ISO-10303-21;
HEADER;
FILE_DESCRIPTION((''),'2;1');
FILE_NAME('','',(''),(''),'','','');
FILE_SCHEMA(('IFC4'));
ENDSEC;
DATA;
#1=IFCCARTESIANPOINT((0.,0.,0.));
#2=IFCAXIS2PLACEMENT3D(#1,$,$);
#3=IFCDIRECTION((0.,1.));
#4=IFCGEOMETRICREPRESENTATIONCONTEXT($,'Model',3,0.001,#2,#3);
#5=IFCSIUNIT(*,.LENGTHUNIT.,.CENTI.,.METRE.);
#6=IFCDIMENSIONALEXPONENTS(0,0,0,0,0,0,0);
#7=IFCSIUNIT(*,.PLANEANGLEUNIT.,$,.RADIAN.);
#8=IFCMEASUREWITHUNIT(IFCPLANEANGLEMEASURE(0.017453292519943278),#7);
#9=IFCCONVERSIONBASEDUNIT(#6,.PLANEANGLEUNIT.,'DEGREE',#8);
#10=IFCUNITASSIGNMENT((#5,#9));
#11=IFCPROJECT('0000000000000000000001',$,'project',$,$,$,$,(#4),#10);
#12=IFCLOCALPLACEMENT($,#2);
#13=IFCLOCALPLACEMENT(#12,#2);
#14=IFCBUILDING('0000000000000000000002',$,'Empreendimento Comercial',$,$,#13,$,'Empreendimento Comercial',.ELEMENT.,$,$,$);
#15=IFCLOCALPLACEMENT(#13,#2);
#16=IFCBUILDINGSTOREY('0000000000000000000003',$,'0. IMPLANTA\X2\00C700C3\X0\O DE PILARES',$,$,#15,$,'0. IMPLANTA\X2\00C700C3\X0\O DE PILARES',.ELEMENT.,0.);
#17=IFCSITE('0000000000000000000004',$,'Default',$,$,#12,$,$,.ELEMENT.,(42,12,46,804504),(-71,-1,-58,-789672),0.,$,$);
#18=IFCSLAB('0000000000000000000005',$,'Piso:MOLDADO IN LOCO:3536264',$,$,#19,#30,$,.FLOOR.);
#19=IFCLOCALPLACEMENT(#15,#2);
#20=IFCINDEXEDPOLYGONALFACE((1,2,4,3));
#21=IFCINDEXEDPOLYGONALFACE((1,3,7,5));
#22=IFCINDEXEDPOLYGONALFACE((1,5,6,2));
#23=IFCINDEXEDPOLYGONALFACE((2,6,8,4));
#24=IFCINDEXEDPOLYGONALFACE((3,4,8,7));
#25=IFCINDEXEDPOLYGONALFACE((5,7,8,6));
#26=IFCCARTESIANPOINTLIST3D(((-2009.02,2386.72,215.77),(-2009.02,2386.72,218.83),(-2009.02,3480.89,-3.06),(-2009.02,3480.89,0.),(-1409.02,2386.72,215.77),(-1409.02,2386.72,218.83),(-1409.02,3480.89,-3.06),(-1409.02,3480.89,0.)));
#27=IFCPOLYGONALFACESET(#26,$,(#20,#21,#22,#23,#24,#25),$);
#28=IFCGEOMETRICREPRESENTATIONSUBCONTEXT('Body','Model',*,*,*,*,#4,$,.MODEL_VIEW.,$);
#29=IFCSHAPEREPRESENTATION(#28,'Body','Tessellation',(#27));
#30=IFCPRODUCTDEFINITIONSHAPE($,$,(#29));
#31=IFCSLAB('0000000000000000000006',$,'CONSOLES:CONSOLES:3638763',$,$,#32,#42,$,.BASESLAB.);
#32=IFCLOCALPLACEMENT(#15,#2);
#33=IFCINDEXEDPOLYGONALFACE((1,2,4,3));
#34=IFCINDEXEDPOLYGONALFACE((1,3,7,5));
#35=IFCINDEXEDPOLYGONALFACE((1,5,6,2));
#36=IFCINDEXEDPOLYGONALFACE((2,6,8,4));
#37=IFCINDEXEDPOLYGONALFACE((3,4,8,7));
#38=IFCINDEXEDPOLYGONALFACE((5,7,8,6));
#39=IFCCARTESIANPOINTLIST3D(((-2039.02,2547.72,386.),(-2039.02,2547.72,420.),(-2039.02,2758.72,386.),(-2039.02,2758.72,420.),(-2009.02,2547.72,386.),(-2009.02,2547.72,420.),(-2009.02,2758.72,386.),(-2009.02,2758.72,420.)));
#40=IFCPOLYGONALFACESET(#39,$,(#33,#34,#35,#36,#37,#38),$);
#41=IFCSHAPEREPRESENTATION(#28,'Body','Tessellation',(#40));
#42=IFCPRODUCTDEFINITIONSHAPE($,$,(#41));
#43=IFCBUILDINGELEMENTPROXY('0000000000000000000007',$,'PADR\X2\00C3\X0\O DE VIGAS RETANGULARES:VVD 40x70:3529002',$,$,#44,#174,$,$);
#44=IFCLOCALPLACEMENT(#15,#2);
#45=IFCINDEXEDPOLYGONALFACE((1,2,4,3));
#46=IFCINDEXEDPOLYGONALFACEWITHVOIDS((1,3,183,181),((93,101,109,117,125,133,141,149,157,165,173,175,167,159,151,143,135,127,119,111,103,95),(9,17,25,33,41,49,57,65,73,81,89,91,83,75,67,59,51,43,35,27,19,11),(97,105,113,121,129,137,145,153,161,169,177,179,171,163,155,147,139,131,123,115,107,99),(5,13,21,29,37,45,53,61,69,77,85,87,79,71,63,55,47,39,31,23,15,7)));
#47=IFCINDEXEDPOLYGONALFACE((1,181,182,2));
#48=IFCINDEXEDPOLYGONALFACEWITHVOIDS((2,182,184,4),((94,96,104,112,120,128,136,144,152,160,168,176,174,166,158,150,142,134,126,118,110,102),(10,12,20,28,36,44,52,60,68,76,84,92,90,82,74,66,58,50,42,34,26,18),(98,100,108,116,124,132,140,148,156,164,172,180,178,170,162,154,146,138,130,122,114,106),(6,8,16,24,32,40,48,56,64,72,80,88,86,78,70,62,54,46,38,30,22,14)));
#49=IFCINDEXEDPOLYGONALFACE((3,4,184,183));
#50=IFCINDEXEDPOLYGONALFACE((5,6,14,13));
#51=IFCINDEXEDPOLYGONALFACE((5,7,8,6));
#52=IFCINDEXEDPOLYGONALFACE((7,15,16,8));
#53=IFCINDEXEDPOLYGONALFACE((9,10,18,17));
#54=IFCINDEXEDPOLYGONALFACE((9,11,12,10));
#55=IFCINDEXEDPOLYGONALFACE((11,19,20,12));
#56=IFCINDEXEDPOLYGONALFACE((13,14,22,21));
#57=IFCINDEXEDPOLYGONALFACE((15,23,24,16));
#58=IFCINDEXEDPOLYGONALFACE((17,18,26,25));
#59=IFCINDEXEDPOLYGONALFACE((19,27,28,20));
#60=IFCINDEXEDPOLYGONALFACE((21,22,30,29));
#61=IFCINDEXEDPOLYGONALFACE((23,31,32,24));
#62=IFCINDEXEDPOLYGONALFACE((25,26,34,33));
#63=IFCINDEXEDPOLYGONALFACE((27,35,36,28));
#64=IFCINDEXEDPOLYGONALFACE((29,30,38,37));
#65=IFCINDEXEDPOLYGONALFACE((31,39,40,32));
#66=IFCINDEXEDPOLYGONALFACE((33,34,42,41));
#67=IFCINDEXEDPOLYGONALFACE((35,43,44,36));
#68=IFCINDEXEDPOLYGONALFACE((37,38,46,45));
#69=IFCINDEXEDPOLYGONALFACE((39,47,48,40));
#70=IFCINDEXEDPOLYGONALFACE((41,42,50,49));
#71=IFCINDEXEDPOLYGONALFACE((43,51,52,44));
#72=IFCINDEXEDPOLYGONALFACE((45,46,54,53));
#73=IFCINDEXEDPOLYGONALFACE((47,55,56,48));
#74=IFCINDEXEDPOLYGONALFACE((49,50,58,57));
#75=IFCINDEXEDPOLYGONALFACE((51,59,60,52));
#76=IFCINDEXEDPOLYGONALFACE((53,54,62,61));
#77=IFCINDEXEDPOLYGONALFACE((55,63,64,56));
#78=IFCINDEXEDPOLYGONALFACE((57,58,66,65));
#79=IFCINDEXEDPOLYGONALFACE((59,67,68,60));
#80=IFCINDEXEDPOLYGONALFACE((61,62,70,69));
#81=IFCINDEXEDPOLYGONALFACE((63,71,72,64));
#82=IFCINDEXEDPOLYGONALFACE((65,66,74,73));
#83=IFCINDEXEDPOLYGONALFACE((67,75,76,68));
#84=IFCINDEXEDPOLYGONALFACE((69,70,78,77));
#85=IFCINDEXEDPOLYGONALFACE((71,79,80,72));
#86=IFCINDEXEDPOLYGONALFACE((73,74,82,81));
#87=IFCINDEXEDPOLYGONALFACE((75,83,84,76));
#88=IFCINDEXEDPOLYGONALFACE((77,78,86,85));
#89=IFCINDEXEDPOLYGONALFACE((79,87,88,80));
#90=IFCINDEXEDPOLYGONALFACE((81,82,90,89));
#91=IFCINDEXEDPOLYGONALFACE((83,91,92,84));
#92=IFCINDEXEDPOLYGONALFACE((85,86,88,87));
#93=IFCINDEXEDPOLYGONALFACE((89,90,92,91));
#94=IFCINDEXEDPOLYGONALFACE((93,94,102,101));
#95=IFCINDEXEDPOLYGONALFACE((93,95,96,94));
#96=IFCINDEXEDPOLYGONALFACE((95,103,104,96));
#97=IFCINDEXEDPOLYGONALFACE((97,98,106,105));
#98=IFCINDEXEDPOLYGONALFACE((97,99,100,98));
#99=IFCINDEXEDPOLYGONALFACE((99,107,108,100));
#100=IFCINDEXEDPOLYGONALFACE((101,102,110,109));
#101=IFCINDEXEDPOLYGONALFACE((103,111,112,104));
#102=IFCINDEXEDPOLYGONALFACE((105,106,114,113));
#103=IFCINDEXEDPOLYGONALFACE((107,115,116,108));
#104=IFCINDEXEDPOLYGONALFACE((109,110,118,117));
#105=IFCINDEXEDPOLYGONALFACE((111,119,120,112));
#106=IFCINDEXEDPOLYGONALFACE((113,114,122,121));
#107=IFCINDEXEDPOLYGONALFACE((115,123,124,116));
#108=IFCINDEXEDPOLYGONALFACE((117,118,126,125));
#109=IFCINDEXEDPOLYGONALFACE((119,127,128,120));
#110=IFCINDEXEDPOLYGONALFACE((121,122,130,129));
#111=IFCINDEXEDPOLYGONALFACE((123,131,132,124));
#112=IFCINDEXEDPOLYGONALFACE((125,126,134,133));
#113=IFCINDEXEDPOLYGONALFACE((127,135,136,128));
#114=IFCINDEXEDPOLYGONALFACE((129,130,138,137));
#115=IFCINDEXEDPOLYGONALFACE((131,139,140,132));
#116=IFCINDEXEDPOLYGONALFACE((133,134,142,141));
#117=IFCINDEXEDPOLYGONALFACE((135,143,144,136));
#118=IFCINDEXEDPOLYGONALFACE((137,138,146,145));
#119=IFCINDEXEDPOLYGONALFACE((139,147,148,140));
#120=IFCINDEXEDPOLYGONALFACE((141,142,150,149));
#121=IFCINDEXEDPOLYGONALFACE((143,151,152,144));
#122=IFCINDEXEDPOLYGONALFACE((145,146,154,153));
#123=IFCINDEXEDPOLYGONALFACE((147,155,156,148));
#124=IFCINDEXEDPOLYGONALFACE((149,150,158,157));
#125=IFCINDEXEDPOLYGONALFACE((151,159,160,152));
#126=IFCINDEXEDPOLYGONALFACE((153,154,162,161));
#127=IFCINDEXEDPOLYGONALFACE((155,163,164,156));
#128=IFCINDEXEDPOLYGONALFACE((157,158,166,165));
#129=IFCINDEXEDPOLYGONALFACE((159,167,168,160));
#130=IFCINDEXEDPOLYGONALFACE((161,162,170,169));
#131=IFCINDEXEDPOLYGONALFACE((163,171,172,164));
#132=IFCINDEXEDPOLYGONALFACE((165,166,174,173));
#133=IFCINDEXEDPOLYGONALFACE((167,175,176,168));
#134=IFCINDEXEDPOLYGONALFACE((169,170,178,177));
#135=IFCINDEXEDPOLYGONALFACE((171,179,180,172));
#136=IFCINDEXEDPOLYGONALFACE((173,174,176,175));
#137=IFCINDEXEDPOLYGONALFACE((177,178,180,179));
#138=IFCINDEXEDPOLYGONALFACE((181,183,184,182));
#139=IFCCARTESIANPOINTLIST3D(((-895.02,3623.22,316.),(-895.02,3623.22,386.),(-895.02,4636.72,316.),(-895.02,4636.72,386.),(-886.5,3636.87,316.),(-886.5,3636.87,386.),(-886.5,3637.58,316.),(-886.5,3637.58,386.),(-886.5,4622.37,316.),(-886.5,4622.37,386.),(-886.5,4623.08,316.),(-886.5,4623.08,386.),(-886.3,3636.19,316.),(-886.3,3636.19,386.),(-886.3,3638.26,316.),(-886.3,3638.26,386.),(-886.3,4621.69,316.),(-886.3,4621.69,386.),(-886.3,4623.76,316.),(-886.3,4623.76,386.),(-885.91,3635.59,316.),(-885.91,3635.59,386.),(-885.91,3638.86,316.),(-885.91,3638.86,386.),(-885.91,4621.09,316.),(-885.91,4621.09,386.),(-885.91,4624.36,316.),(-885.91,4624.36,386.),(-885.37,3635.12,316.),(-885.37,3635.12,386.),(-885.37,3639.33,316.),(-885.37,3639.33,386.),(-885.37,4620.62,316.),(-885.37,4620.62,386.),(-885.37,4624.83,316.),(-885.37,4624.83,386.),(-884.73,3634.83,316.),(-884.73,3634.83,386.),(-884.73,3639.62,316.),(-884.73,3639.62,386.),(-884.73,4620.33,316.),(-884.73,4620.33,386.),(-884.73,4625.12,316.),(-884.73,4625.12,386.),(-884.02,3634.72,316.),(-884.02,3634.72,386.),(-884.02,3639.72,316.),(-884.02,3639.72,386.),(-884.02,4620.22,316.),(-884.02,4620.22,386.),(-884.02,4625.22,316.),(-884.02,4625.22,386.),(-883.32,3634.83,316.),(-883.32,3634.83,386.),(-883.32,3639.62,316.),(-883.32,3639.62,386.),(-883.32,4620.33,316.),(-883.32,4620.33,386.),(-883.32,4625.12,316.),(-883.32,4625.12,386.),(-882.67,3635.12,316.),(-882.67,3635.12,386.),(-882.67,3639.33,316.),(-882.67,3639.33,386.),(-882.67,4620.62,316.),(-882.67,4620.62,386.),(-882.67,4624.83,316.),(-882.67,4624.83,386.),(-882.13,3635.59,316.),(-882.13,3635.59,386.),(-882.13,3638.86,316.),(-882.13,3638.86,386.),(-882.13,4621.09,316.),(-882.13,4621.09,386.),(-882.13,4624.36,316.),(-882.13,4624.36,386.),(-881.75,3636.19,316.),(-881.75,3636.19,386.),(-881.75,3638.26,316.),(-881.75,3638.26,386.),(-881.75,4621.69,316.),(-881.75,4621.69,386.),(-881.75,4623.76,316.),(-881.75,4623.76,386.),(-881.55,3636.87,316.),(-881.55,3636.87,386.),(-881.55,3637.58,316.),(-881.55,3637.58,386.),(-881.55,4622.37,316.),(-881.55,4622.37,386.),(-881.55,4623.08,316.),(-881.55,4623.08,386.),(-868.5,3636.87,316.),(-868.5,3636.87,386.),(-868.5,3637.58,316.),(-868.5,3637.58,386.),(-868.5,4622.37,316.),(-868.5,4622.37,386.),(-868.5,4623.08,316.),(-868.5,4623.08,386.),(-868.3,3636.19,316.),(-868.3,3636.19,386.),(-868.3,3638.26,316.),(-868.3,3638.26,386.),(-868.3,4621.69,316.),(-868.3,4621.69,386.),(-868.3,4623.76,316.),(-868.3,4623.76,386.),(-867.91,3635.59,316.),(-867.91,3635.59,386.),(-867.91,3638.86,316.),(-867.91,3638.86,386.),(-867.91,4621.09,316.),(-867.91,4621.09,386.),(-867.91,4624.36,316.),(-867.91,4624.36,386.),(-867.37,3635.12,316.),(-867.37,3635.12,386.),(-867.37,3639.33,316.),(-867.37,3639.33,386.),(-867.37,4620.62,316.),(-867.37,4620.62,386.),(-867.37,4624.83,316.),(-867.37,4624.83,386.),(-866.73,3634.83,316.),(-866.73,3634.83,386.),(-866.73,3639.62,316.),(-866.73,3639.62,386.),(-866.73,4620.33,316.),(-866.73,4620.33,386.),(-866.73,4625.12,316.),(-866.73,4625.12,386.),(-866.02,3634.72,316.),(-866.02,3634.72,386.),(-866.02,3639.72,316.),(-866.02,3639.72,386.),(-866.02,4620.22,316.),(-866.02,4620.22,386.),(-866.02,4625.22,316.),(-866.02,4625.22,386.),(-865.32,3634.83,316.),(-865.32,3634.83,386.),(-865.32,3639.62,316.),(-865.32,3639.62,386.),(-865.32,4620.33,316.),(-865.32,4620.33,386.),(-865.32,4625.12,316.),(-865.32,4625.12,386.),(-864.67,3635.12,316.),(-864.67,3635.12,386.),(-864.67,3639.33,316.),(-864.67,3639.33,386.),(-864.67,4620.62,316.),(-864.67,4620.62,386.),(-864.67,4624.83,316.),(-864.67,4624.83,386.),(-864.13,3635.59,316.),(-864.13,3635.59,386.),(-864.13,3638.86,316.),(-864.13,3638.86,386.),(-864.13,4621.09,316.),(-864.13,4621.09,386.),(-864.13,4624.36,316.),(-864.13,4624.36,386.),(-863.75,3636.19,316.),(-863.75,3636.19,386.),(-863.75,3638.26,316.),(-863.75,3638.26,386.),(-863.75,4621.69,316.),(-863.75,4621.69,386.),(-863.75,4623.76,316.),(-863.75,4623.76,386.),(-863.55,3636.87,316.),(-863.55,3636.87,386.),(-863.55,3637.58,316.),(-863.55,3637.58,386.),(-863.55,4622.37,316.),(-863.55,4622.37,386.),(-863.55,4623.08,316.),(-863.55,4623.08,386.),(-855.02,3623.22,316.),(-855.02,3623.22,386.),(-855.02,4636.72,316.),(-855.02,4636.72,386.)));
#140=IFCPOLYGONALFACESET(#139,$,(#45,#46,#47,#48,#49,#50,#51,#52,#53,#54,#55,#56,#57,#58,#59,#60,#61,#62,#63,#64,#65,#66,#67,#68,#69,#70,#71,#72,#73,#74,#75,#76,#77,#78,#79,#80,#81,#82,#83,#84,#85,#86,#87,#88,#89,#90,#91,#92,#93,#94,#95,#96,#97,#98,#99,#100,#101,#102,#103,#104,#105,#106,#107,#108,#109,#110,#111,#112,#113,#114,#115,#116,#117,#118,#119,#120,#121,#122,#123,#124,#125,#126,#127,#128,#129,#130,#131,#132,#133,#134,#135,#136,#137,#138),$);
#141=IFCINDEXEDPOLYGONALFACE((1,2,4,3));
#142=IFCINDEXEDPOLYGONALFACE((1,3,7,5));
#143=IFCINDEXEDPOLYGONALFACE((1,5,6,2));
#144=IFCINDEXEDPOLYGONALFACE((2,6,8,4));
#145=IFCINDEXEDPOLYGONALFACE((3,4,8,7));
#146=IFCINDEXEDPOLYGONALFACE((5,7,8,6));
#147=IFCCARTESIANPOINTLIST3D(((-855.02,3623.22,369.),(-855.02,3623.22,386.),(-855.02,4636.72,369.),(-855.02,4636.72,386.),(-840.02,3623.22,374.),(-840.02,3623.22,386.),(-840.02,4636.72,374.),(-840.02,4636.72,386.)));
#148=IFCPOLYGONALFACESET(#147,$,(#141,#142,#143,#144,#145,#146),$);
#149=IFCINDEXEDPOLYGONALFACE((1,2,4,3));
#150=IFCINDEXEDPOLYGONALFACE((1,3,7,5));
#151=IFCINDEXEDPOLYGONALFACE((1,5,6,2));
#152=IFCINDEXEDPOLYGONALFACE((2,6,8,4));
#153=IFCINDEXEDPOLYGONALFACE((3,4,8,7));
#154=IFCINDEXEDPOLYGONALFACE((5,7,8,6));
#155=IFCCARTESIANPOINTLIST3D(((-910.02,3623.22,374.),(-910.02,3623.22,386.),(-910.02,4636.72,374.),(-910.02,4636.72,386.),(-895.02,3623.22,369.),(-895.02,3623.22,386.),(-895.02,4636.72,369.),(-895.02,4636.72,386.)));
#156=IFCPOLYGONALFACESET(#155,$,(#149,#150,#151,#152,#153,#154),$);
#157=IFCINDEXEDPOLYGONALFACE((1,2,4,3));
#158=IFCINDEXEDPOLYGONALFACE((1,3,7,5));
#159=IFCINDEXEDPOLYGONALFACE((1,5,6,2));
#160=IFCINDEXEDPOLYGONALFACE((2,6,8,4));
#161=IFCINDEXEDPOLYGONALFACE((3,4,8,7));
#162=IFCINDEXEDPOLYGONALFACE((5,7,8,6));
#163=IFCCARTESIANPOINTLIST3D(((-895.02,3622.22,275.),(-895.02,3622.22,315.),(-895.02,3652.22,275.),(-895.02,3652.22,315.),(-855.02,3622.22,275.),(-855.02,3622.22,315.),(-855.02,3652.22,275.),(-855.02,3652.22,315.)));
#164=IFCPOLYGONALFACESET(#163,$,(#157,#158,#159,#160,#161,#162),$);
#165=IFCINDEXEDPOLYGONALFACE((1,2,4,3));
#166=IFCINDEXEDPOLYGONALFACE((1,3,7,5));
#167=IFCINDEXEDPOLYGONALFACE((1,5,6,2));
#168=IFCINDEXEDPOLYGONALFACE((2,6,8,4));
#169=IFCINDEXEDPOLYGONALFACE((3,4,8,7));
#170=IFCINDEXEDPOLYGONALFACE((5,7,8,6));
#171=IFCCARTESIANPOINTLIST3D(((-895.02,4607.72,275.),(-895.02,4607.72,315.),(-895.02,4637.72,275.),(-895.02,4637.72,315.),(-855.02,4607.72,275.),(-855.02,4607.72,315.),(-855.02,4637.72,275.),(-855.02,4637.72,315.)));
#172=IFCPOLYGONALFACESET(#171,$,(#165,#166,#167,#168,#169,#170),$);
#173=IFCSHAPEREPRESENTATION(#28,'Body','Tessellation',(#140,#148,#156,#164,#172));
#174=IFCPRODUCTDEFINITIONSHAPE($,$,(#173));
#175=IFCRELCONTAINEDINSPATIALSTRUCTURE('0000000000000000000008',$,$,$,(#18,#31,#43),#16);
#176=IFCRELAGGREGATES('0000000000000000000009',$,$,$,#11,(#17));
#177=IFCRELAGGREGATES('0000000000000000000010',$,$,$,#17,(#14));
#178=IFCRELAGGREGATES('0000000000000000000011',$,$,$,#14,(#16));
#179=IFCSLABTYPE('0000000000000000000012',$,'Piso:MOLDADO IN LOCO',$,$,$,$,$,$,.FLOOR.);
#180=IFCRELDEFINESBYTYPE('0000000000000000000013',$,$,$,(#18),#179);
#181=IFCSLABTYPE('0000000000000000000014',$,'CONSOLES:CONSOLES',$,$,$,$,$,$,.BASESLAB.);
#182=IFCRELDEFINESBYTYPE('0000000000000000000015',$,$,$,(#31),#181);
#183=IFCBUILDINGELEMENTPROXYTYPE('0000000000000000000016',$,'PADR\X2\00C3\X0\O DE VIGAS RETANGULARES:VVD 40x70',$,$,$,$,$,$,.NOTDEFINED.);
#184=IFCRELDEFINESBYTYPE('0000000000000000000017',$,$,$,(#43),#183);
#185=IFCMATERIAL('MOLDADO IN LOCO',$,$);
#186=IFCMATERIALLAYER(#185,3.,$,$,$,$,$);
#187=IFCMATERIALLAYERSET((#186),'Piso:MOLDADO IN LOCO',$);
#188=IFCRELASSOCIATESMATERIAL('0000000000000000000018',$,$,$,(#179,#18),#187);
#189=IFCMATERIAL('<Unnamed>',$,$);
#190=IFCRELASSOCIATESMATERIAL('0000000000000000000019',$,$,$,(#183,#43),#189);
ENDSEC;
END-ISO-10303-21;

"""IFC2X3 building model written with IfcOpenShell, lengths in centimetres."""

from ifc_helpers import new_model, entity, si_unit, converted_unit, direction, frame, frame_2d, origin, place, context, subcontext, project, spatial, polyline, circle_curve, parameter, trimmed, segment, composite_curve, rectangle, outline, extrude, clip, halfspace, source, transform, mapped, material, layer, layer_set, layer_usage, type_object, type_shapes, element, save


model = new_model("IFC2X3")

# Units and contexts
model_context = context("Model", 3, precision=0.001, world=origin(), true_north=direction((0.0, 1.0)))
body_context = subcontext(model_context, "Body", "Model", "MODEL_VIEW")
ifc_project = project(units=[si_unit("LENGTHUNIT", "METRE", prefix="CENTI"), converted_unit("PLANEANGLEUNIT", "DEGREE", entity("IfcPlaneAngleMeasure", 0.017453292519943278), si_unit("PLANEANGLEUNIT", "RADIAN"), dimensions=[0, 0, 0, 0, 0, 0, 0])], contexts=[model_context])

# Site, building, storey
site_placement = place(None, origin())
site = spatial("IfcSite", under=ifc_project, at=site_placement, Name="Default", CompositionType="ELEMENT", RefLatitude=(42, 12, 46, 804504), RefLongitude=(-71, -1, -58, -789672), RefElevation=0.0)
building_placement = place(site_placement, origin())
building = spatial("IfcBuilding", under=site, at=building_placement, Name="Empreendimento Comercial", LongName="Empreendimento Comercial", CompositionType="ELEMENT")
storey_placement = place(building_placement, origin())
storey = spatial("IfcBuildingStorey", under=building, at=storey_placement, Name="0. IMPLANTAÇÃO DE PILARES", LongName="0. IMPLANTAÇÃO DE PILARES", CompositionType="ELEMENT", Elevation=0.0)

# Slabs
ifc_material_1 = material(Name="MOLDADO IN LOCO")
ifc_layer_1 = layer(ifc_material_1, 3.0)
ifc_layer_set_1 = layer_set([ifc_layer_1], Name="Piso:MOLDADO IN LOCO")
ifc_layer_usage_1 = layer_usage(ifc_layer_set_1, "AXIS3", "POSITIVE", 0.0)
slab_type_1 = type_object("IfcSlabType", Name="Piso:MOLDADO IN LOCO", PredefinedType="FLOOR", material=ifc_layer_set_1)
slab_1_placement = place(storey_placement, origin())
element("IfcSlab", 1, at=slab_1_placement, inside=storey, type_object=slab_type_1, material=ifc_layer_usage_1, Name="Piso:MOLDADO IN LOCO:3536264", PredefinedType="FLOOR", context=body_context, shape_type="Clipping", body=[
    clip(clip(extrude(rectangle(XDim=1115.83, YDim=600.0, at=frame_2d((0.0, 0.0), x_axis=(1.0, 0.0))), frame((-1709.02, 2933.81, 109.42), z_axis=(0.0, -0.196116, -0.980581), x_axis=(0.0, 0.980581, -0.196116)), (0.196116, 0.0, 0.980581), 3.12), halfspace(frame((-1679.02, 3480.89, -3.06), z_axis=(0.0, -0.196116, -0.980581), x_axis=(0.0, -0.980581, 0.196116)), False)), halfspace(frame((-1679.02, 3480.89, 0.0), z_axis=(0.0, 0.196116, 0.980581), x_axis=(0.0, 0.980581, -0.196116)), False)),
])
slab_type_2 = type_object("IfcSlabType", Name="CONSOLES:CONSOLES", PredefinedType="BASESLAB")
slab_2_placement = place(storey_placement, origin())
element("IfcSlab", 2, at=slab_2_placement, inside=storey, type_object=slab_type_2, Name="CONSOLES:CONSOLES:3638763", PredefinedType="BASESLAB", context=body_context, shape_type="SweptSolid", body=[
    extrude(rectangle(XDim=211.0, YDim=30.0, at=frame_2d((0.0, 0.0), x_axis=(1.0, 0.0))), frame((-2024.02, 2653.22, 386.0), z_axis=(0.0, 0.0, 1.0), x_axis=(0.0, 1.0, 0.0)), (0.0, 0.0, 1.0), 34.0),
])

# Building element proxy
ifc_material_2 = material(Name="<Unnamed>")
building_element_proxy_type_1 = type_object("IfcBuildingElementProxyType", Name="PADRÃO DE VIGAS RETANGULARES:VVD 40x70", PredefinedType="NOTDEFINED", material=ifc_material_2)
shared_shape_1 = source(origin(), body_context, "Body", "SweptSolid", [
    extrude(outline(polyline([(-506.75, -20.0), (506.75, -20.0), (506.75, 20.0), (-506.75, 20.0), (-506.75, -20.0)]), holes=[composite_curve([segment(trimmed(circle_curve(frame_2d((-492.75, -9.0), x_axis=(-1.0, 0.0)), 2.5), [parameter(0.0)], [parameter(180.0)], True, "PARAMETER"), False, "CONTINUOUS"), segment(trimmed(circle_curve(frame_2d((-492.75, -9.0), x_axis=(-1.0, 0.0)), 2.5), [parameter(180.0)], [parameter(0.0)], True, "PARAMETER"), False, "CONTINUOUS")], self_intersect=False), composite_curve([segment(trimmed(circle_curve(frame_2d((-492.75, 9.0), x_axis=(-1.0, 0.0)), 2.5), [parameter(0.0)], [parameter(180.0)], True, "PARAMETER"), False, "CONTINUOUS"), segment(trimmed(circle_curve(frame_2d((-492.75, 9.0), x_axis=(-1.0, 0.0)), 2.5), [parameter(180.0)], [parameter(0.0)], True, "PARAMETER"), False, "CONTINUOUS")], self_intersect=False), composite_curve([segment(trimmed(circle_curve(frame_2d((492.75, 9.0), x_axis=(-1.0, 0.0)), 2.5), [parameter(0.0)], [parameter(180.0)], True, "PARAMETER"), False, "CONTINUOUS"), segment(trimmed(circle_curve(frame_2d((492.75, 9.0), x_axis=(-1.0, 0.0)), 2.5), [parameter(180.0)], [parameter(0.0)], True, "PARAMETER"), False, "CONTINUOUS")], self_intersect=False), composite_curve([segment(trimmed(circle_curve(frame_2d((492.75, -9.0), x_axis=(-1.0, 0.0)), 2.5), [parameter(0.0)], [parameter(180.0)], True, "PARAMETER"), False, "CONTINUOUS"), segment(trimmed(circle_curve(frame_2d((492.75, -9.0), x_axis=(-1.0, 0.0)), 2.5), [parameter(180.0)], [parameter(0.0)], True, "PARAMETER"), False, "CONTINUOUS")], self_intersect=False)]), frame((-875.02, 4129.97, 316.0), z_axis=(0.0, 0.0, 1.0), x_axis=(0.0, -1.0, 0.0)), (0.0, 0.0, 1.0), 70.0),
    extrude(outline(polyline([(-7.25, -7.5), (4.75, -7.5), (9.75, 7.5), (-7.25, 7.5), (-7.25, -7.5)])), frame((-847.52, 3623.22, 378.75), z_axis=(0.0, 1.0, 0.0), x_axis=(0.0, 0.0, -1.0)), (0.0, 0.0, 1.0), 1013.5),
    extrude(outline(polyline([(-7.5, -7.25), (7.5, -7.25), (7.5, 9.75), (-7.5, 4.75), (-7.5, -7.25)])), frame((-902.52, 3623.22, 378.75), z_axis=(0.0, 1.0, 0.0), x_axis=(1.0, 0.0, 0.0)), (0.0, 0.0, 1.0), 1013.5),
    extrude(rectangle(XDim=40.0, YDim=30.0, at=frame_2d((0.0, 0.0), x_axis=(1.0, 0.0))), frame((-875.02, 3637.22, 275.0), z_axis=(0.0, 0.0, 1.0), x_axis=(-1.0, 0.0, 0.0)), (0.0, 0.0, 1.0), 40.0),
    extrude(rectangle(XDim=40.0, YDim=30.0, at=frame_2d((0.0, 0.0), x_axis=(1.0, 0.0))), frame((-875.02, 4622.72, 275.0), z_axis=(0.0, 0.0, 1.0), x_axis=(-1.0, 0.0, 0.0)), (0.0, 0.0, 1.0), 40.0),
])
type_shapes(building_element_proxy_type_1, [shared_shape_1])
proxy_1_placement = place(storey_placement, origin())
element("IfcBuildingElementProxy", 3, at=proxy_1_placement, inside=storey, type_object=building_element_proxy_type_1, material=ifc_material_2, Name="PADRÃO DE VIGAS RETANGULARES:VVD 40x70:3529002", context=body_context, shape_type="MappedRepresentation", body=[
    mapped(shared_shape_1, transform((0.0, 0.0, 0.0), scale=1.0)),
])

save(model, "model.ifc")
